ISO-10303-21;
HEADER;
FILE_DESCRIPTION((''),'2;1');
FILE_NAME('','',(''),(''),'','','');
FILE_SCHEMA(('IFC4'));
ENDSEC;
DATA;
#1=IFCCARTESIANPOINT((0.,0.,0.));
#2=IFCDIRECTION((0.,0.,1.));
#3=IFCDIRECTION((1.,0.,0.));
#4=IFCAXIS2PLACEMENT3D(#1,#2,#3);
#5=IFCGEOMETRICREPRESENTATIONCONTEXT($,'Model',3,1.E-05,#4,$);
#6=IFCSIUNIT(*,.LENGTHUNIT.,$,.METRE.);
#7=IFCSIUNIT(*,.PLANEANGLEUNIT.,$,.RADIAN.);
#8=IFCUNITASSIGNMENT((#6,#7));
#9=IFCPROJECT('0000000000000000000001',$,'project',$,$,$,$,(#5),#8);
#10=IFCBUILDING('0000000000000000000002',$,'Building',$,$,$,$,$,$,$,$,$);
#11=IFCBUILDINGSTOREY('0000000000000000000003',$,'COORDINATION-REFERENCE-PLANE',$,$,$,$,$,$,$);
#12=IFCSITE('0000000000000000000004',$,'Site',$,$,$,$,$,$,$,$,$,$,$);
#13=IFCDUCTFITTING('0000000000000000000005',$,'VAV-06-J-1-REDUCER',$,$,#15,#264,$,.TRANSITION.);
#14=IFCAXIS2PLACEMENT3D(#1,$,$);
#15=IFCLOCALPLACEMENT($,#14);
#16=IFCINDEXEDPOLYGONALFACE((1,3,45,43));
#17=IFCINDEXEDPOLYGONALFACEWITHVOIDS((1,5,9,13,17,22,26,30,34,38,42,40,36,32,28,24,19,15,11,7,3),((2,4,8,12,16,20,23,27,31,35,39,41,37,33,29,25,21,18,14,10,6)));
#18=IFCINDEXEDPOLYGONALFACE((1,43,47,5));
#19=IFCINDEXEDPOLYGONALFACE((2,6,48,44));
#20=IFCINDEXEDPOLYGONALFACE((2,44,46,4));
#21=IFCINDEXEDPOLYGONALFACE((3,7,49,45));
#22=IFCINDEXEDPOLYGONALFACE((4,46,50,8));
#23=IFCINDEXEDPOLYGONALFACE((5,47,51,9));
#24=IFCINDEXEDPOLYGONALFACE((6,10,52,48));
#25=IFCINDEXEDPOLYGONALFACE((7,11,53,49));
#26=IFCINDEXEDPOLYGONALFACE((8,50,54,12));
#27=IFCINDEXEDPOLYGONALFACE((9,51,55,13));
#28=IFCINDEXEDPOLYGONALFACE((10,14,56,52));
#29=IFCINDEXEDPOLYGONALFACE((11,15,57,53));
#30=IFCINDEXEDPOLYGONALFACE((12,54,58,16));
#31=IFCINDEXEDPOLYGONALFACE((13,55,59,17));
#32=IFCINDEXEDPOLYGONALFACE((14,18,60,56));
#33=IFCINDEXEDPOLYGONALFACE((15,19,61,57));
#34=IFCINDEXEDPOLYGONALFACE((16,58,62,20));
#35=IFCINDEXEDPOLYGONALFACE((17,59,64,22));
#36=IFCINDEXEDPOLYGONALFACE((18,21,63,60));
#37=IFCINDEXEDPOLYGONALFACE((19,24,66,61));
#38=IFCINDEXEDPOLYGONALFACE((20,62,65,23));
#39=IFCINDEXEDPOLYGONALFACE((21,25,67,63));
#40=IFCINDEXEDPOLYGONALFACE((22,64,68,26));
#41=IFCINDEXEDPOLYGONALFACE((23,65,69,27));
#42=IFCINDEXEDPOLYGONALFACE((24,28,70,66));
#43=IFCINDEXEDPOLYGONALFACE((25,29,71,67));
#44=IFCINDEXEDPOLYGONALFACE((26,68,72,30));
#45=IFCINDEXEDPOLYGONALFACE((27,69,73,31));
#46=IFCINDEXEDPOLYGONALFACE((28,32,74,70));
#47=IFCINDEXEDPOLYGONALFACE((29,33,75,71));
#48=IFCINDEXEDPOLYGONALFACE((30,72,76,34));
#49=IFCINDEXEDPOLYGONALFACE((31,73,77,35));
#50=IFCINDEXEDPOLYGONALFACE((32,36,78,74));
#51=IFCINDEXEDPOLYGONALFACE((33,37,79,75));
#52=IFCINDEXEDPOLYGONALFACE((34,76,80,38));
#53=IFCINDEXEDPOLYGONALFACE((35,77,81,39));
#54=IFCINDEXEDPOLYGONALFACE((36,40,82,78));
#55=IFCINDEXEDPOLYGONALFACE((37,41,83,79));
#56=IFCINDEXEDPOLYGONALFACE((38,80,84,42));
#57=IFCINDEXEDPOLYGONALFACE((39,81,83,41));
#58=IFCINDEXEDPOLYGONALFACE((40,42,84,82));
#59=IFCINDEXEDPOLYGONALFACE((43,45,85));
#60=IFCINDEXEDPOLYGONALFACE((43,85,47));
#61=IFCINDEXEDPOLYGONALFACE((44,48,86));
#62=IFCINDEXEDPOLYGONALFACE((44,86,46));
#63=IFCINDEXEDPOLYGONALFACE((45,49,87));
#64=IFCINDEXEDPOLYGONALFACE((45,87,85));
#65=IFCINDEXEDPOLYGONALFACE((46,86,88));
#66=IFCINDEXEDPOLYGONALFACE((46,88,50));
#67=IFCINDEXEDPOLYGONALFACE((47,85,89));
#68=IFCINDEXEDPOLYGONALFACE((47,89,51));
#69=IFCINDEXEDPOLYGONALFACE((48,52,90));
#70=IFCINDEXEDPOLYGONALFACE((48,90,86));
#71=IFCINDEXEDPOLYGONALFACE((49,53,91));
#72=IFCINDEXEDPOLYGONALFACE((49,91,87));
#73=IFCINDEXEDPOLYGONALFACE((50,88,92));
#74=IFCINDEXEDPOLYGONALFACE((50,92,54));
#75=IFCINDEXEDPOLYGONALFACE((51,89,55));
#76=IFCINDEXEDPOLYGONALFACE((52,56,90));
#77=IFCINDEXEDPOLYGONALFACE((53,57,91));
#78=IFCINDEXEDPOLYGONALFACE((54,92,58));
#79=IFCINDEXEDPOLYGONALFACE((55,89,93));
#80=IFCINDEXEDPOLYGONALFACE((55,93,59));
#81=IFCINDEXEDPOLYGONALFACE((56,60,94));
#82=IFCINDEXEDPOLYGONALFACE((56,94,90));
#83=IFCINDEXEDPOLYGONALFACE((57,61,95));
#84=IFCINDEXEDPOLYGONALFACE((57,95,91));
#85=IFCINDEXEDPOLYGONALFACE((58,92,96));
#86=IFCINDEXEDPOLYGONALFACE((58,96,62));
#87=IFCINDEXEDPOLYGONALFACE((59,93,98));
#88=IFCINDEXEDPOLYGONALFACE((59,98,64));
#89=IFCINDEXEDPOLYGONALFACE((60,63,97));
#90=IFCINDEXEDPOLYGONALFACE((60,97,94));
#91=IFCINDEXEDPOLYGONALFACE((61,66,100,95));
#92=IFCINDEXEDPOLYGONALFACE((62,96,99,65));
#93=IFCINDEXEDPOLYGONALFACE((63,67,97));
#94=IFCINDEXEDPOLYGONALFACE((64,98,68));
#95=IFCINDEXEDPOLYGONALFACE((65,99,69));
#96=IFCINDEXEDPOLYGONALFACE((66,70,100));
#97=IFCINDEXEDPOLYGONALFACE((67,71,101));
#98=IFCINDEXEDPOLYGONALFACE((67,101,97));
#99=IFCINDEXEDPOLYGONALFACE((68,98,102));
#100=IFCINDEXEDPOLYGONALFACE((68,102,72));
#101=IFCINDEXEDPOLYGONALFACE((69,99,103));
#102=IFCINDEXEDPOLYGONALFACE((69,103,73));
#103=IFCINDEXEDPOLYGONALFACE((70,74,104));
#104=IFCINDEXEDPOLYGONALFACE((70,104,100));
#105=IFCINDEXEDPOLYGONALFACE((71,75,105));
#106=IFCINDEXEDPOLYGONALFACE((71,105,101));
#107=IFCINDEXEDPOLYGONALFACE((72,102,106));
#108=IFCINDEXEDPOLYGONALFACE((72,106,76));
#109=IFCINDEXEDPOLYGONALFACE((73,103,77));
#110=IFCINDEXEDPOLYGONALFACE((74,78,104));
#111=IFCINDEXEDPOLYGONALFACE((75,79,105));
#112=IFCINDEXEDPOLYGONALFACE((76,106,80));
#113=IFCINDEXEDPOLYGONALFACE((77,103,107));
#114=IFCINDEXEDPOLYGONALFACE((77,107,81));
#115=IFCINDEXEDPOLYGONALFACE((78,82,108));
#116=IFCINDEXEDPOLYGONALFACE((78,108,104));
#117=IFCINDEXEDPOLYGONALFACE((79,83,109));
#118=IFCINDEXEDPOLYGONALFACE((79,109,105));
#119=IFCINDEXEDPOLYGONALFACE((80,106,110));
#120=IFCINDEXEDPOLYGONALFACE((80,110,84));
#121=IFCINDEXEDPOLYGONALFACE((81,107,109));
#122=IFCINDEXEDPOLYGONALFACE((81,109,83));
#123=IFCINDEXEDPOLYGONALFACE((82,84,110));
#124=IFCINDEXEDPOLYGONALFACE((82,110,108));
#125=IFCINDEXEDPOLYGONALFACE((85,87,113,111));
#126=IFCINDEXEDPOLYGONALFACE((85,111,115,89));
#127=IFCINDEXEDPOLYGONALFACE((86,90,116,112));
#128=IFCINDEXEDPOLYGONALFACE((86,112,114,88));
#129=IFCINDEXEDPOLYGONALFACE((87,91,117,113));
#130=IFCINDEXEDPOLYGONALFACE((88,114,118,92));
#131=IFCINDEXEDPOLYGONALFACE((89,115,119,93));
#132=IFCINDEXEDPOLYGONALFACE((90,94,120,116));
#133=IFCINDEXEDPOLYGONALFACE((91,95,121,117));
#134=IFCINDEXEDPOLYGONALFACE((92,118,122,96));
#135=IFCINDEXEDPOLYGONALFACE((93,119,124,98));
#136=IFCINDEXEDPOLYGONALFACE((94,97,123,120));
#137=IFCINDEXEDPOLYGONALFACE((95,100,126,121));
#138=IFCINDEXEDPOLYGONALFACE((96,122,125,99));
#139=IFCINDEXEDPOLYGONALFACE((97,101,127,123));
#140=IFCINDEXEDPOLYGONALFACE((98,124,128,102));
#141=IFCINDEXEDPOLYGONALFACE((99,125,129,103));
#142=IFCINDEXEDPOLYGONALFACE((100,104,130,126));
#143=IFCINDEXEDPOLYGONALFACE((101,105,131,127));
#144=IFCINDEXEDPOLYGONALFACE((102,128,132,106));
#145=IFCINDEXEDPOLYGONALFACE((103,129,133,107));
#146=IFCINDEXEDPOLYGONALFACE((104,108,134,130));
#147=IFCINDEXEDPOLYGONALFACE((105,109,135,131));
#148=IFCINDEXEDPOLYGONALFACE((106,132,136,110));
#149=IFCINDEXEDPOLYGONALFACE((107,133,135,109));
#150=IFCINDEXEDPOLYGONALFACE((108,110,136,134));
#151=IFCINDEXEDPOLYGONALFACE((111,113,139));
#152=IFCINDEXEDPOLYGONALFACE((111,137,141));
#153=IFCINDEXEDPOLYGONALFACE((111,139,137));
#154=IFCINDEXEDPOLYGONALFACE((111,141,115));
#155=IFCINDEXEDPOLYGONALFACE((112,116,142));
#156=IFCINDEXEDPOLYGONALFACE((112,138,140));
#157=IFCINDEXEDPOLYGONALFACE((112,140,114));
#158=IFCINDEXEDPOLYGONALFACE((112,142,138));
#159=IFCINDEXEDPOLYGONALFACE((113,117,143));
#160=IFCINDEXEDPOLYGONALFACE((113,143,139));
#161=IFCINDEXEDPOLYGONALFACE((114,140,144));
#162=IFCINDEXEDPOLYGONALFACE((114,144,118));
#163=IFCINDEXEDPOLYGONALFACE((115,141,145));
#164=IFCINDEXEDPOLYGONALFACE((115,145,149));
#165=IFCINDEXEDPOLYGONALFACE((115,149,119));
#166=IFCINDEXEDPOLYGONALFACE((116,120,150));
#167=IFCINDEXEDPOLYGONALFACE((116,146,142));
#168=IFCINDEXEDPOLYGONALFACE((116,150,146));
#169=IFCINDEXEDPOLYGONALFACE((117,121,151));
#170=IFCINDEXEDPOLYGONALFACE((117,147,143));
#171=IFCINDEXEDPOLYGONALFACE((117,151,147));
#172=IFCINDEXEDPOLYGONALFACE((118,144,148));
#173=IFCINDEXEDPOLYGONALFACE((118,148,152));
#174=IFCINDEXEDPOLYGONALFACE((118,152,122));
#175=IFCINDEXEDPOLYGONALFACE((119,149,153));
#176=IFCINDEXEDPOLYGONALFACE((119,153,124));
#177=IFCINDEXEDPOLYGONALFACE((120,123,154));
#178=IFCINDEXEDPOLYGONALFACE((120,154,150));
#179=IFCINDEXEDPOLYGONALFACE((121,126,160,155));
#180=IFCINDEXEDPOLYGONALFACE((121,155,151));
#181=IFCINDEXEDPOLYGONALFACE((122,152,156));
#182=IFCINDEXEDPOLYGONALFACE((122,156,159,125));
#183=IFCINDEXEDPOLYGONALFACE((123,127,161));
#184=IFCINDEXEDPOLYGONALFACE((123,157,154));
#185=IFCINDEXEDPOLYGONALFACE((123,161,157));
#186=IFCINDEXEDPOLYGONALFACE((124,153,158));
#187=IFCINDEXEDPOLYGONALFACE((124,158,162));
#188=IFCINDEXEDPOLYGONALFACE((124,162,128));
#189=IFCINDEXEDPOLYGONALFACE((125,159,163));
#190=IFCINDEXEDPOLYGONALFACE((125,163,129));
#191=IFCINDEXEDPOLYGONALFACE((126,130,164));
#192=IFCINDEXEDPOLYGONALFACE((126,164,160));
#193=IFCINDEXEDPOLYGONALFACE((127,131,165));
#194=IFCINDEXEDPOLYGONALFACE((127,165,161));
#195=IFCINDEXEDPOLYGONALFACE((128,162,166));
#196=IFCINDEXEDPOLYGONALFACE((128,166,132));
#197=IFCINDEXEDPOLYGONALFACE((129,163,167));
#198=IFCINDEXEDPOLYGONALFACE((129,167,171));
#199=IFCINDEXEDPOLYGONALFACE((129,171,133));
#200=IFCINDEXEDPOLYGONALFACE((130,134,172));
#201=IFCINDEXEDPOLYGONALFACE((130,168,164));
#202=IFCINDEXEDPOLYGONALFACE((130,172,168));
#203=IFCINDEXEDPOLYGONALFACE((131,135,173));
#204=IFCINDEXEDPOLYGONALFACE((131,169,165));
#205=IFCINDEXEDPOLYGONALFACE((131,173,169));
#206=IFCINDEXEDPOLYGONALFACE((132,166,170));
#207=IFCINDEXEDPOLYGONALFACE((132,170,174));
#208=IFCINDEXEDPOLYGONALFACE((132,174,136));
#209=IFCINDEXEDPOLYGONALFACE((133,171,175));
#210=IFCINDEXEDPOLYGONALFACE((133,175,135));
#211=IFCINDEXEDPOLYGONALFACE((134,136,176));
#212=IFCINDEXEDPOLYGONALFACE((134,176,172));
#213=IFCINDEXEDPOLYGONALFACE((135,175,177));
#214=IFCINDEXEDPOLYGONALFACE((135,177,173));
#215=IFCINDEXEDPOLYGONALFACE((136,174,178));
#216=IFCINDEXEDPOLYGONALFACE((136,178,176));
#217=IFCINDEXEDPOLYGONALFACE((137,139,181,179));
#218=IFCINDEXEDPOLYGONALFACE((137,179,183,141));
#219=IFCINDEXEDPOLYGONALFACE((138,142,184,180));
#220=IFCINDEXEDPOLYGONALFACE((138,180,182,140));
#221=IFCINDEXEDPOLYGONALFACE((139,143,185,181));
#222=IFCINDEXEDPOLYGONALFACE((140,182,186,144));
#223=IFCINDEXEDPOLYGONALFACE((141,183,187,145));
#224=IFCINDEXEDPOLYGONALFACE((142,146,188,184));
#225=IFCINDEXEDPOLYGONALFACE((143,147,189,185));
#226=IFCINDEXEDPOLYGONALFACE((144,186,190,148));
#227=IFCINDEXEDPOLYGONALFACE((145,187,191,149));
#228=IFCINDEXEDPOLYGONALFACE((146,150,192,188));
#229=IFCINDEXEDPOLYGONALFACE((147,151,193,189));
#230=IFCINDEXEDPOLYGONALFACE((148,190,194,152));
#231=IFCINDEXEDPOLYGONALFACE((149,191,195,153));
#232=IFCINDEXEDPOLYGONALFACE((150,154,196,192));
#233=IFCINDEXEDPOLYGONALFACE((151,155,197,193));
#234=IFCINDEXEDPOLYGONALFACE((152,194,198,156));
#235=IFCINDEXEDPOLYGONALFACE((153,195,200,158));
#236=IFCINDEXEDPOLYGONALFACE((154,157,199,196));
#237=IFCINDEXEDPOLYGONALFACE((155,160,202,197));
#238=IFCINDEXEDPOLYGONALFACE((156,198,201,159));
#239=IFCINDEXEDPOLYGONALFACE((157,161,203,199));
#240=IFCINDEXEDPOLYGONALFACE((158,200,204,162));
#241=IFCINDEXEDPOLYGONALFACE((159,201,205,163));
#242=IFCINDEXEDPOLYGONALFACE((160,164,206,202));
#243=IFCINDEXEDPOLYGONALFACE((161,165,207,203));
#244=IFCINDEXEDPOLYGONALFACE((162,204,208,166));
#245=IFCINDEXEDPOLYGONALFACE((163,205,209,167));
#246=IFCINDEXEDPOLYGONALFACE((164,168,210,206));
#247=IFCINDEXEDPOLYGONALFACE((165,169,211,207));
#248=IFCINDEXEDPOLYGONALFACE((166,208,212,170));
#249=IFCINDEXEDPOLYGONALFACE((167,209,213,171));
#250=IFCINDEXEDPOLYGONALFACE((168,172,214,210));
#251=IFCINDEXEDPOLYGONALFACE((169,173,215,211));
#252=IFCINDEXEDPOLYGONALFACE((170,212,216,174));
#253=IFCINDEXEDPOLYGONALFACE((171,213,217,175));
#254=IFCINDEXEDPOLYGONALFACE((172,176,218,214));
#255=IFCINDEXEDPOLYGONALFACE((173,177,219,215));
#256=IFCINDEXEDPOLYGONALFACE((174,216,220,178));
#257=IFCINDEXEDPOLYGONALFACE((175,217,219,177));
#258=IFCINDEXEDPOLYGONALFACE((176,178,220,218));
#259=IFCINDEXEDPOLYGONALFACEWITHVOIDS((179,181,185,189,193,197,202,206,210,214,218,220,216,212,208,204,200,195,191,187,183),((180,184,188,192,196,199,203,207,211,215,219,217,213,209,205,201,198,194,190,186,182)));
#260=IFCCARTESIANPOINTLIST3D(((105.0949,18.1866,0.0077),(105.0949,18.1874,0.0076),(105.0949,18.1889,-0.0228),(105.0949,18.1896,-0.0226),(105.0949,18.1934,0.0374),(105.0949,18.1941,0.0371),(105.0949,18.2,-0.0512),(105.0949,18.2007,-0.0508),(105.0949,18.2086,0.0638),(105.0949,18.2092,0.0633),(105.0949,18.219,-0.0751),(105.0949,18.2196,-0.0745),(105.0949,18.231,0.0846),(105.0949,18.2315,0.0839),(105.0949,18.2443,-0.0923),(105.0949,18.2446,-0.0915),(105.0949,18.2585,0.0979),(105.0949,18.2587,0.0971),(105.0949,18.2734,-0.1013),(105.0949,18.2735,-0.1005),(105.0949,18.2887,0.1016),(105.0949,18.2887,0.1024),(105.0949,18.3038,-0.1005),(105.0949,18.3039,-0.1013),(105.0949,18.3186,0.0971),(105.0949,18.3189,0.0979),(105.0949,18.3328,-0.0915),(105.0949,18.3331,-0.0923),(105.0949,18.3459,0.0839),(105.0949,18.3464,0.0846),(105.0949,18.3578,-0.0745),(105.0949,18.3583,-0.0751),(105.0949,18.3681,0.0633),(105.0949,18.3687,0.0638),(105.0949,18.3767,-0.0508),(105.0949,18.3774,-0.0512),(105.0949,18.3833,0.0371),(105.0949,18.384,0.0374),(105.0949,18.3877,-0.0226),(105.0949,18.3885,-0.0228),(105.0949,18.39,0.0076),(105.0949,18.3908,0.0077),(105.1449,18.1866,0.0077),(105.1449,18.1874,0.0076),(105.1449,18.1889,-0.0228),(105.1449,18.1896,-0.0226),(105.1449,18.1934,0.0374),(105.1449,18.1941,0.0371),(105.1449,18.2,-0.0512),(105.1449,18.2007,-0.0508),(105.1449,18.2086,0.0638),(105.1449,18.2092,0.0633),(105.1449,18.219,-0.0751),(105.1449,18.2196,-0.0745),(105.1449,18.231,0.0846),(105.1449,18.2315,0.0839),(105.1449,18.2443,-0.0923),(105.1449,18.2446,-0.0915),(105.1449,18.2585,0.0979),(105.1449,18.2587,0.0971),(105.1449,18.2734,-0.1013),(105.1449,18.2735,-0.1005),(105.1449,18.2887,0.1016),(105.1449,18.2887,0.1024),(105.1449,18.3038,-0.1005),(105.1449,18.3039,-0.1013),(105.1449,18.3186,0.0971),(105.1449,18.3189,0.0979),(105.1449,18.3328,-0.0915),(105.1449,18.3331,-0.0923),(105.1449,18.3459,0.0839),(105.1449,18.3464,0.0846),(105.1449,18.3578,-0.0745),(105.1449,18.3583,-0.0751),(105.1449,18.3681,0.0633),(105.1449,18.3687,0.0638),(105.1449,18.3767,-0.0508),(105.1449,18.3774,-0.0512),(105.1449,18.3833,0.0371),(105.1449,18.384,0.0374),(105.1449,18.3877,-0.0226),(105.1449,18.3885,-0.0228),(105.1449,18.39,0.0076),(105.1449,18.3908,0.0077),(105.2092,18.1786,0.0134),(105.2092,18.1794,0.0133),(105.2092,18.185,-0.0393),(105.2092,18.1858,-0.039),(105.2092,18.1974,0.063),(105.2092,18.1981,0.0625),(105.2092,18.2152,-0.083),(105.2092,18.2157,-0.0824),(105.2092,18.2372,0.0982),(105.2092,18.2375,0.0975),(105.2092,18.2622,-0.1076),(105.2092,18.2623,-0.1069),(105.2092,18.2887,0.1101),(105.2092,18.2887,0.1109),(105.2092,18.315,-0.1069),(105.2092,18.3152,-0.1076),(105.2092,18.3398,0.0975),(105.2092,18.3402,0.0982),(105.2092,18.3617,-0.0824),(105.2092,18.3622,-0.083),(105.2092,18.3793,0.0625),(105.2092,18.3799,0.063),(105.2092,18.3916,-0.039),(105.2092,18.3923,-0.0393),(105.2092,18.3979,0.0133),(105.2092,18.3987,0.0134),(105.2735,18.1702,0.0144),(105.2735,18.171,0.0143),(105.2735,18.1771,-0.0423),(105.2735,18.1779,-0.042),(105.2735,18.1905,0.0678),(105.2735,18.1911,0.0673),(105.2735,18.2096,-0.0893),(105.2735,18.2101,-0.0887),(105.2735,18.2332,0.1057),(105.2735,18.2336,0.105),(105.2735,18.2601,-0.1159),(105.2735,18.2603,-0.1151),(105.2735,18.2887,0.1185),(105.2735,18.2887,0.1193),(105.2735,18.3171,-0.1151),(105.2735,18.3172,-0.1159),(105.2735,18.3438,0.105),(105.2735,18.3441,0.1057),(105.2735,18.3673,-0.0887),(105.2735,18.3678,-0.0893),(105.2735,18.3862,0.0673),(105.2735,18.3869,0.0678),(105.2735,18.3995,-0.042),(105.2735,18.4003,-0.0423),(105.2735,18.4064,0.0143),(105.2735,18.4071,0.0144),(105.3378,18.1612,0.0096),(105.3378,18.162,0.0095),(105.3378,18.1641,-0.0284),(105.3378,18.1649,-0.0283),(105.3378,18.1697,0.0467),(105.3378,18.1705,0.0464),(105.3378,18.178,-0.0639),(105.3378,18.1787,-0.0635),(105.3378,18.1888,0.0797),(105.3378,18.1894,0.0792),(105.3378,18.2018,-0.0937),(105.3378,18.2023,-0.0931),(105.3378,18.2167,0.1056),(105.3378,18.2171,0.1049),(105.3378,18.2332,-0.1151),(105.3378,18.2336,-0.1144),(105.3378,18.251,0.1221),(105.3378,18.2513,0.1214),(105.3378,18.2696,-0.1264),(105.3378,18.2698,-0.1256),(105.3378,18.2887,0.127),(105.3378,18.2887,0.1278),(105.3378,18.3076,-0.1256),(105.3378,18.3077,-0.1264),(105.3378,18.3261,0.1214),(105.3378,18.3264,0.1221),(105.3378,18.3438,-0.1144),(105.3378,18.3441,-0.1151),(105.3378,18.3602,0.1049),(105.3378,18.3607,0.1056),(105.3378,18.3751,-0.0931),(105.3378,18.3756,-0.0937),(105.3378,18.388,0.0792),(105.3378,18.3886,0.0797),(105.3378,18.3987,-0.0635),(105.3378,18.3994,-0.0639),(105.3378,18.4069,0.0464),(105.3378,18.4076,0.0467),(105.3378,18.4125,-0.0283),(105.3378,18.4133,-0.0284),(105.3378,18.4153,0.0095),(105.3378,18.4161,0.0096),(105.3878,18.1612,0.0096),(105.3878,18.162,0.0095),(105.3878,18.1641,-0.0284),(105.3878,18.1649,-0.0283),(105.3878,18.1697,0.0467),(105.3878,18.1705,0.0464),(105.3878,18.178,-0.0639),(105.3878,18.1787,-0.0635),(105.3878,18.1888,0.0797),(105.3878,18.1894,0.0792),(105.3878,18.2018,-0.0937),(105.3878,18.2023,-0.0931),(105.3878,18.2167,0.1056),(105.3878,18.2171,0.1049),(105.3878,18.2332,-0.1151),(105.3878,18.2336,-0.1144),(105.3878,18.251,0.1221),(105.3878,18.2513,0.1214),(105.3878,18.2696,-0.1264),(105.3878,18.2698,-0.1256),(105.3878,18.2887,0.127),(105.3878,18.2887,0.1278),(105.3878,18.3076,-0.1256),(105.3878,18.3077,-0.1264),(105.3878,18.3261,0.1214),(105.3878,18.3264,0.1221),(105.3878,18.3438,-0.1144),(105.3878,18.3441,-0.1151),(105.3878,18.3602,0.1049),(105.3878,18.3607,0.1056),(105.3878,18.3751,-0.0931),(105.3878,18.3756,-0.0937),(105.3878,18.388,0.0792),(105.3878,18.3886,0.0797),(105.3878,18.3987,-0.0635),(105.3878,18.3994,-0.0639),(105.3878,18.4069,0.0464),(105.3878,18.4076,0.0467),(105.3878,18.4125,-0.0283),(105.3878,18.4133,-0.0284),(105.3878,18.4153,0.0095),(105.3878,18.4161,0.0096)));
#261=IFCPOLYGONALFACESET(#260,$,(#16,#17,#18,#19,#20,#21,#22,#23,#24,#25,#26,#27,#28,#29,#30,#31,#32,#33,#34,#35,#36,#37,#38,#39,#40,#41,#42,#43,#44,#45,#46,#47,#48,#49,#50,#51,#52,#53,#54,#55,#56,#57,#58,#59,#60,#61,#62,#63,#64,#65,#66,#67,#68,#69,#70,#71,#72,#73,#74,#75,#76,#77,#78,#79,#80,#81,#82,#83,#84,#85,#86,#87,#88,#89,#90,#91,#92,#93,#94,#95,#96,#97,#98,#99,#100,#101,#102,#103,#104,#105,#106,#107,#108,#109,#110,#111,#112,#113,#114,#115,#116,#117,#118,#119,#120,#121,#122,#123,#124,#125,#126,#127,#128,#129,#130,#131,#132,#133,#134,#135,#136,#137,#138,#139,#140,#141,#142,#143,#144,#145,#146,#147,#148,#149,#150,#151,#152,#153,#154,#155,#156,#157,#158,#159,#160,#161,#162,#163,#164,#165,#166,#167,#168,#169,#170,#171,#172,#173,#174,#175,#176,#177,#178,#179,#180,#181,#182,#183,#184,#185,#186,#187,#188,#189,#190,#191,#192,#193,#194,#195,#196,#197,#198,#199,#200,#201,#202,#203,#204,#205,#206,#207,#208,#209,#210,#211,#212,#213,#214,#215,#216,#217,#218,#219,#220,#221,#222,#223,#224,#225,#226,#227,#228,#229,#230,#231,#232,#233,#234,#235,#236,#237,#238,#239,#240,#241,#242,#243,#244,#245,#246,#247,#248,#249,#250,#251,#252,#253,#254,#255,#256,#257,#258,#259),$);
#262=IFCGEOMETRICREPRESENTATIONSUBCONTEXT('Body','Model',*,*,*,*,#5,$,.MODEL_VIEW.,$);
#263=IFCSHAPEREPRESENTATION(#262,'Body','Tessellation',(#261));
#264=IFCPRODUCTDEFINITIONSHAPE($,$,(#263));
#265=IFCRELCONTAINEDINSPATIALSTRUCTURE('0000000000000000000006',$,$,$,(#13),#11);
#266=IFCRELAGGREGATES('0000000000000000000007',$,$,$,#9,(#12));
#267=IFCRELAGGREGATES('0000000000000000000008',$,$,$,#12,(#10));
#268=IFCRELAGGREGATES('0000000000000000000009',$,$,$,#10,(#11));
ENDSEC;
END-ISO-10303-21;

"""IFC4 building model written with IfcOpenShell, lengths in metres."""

from ifc_helpers import new_model, entity, si_unit, frame, origin_with_axes, place, context, subcontext, project, spatial, element, save


model = new_model("IFC4")

# Units and contexts
model_context = context("Model", 3, precision=1e-05, world=origin_with_axes())
body_context_1 = subcontext(model_context, "Body", "Model", "MODEL_VIEW")
ifc_project = project(units=[si_unit("LENGTHUNIT", "METRE"), si_unit("PLANEANGLEUNIT", "RADIAN")], contexts=[model_context])

# Site, building, storey
site = spatial("IfcSite", under=ifc_project, Name="Site")
building = spatial("IfcBuilding", under=site, Name="Building")
storey = spatial("IfcBuildingStorey", under=building, Name="COORDINATION-REFERENCE-PLANE")

# Duct fitting
for number, where, z_axis, x_axis, name in (
    (1, (105.3878, 18.2887, 0.0), (0.0, -1.0, 0.0), (0.0, 0.0, 1.0), "VAV-06-J-1-REDUCER"),
):
    element("IfcDuctFitting", number, at=place(None, frame(where, z_axis=z_axis, x_axis=x_axis)), inside=storey, Name=name, PredefinedType="TRANSITION", context=body_context_1, shape_type="SweptSolid", body=[
        entity("IfcRevolvedAreaSolid", entity("IfcArbitraryClosedProfileDef", "AREA", None, entity("IfcPolyline", [entity("IfcCartesianPoint", [0.1278, 0.0]), entity("IfcCartesianPoint", [0.1278, 0.05]), entity("IfcCartesianPoint", [0.1024, 0.2429]), entity("IfcCartesianPoint", [0.1024, 0.2929]), entity("IfcCartesianPoint", [0.1016, 0.2929]), entity("IfcCartesianPoint", [0.1016, 0.2429]), entity("IfcCartesianPoint", [0.127, 0.05]), entity("IfcCartesianPoint", [0.127, 0.0]), entity("IfcCartesianPoint", [0.1278, 0.0])])), entity("IfcAxis2Placement3D", entity("IfcCartesianPoint", [0.0, 0.0, 0.0])), entity("IfcAxis1Placement", entity("IfcCartesianPoint", [0.0, 0.0, 0.0]), entity("IfcDirection", [0.0, 1.0, 0.0])), 6.283185),
    ])

save(model, "model.ifc")
